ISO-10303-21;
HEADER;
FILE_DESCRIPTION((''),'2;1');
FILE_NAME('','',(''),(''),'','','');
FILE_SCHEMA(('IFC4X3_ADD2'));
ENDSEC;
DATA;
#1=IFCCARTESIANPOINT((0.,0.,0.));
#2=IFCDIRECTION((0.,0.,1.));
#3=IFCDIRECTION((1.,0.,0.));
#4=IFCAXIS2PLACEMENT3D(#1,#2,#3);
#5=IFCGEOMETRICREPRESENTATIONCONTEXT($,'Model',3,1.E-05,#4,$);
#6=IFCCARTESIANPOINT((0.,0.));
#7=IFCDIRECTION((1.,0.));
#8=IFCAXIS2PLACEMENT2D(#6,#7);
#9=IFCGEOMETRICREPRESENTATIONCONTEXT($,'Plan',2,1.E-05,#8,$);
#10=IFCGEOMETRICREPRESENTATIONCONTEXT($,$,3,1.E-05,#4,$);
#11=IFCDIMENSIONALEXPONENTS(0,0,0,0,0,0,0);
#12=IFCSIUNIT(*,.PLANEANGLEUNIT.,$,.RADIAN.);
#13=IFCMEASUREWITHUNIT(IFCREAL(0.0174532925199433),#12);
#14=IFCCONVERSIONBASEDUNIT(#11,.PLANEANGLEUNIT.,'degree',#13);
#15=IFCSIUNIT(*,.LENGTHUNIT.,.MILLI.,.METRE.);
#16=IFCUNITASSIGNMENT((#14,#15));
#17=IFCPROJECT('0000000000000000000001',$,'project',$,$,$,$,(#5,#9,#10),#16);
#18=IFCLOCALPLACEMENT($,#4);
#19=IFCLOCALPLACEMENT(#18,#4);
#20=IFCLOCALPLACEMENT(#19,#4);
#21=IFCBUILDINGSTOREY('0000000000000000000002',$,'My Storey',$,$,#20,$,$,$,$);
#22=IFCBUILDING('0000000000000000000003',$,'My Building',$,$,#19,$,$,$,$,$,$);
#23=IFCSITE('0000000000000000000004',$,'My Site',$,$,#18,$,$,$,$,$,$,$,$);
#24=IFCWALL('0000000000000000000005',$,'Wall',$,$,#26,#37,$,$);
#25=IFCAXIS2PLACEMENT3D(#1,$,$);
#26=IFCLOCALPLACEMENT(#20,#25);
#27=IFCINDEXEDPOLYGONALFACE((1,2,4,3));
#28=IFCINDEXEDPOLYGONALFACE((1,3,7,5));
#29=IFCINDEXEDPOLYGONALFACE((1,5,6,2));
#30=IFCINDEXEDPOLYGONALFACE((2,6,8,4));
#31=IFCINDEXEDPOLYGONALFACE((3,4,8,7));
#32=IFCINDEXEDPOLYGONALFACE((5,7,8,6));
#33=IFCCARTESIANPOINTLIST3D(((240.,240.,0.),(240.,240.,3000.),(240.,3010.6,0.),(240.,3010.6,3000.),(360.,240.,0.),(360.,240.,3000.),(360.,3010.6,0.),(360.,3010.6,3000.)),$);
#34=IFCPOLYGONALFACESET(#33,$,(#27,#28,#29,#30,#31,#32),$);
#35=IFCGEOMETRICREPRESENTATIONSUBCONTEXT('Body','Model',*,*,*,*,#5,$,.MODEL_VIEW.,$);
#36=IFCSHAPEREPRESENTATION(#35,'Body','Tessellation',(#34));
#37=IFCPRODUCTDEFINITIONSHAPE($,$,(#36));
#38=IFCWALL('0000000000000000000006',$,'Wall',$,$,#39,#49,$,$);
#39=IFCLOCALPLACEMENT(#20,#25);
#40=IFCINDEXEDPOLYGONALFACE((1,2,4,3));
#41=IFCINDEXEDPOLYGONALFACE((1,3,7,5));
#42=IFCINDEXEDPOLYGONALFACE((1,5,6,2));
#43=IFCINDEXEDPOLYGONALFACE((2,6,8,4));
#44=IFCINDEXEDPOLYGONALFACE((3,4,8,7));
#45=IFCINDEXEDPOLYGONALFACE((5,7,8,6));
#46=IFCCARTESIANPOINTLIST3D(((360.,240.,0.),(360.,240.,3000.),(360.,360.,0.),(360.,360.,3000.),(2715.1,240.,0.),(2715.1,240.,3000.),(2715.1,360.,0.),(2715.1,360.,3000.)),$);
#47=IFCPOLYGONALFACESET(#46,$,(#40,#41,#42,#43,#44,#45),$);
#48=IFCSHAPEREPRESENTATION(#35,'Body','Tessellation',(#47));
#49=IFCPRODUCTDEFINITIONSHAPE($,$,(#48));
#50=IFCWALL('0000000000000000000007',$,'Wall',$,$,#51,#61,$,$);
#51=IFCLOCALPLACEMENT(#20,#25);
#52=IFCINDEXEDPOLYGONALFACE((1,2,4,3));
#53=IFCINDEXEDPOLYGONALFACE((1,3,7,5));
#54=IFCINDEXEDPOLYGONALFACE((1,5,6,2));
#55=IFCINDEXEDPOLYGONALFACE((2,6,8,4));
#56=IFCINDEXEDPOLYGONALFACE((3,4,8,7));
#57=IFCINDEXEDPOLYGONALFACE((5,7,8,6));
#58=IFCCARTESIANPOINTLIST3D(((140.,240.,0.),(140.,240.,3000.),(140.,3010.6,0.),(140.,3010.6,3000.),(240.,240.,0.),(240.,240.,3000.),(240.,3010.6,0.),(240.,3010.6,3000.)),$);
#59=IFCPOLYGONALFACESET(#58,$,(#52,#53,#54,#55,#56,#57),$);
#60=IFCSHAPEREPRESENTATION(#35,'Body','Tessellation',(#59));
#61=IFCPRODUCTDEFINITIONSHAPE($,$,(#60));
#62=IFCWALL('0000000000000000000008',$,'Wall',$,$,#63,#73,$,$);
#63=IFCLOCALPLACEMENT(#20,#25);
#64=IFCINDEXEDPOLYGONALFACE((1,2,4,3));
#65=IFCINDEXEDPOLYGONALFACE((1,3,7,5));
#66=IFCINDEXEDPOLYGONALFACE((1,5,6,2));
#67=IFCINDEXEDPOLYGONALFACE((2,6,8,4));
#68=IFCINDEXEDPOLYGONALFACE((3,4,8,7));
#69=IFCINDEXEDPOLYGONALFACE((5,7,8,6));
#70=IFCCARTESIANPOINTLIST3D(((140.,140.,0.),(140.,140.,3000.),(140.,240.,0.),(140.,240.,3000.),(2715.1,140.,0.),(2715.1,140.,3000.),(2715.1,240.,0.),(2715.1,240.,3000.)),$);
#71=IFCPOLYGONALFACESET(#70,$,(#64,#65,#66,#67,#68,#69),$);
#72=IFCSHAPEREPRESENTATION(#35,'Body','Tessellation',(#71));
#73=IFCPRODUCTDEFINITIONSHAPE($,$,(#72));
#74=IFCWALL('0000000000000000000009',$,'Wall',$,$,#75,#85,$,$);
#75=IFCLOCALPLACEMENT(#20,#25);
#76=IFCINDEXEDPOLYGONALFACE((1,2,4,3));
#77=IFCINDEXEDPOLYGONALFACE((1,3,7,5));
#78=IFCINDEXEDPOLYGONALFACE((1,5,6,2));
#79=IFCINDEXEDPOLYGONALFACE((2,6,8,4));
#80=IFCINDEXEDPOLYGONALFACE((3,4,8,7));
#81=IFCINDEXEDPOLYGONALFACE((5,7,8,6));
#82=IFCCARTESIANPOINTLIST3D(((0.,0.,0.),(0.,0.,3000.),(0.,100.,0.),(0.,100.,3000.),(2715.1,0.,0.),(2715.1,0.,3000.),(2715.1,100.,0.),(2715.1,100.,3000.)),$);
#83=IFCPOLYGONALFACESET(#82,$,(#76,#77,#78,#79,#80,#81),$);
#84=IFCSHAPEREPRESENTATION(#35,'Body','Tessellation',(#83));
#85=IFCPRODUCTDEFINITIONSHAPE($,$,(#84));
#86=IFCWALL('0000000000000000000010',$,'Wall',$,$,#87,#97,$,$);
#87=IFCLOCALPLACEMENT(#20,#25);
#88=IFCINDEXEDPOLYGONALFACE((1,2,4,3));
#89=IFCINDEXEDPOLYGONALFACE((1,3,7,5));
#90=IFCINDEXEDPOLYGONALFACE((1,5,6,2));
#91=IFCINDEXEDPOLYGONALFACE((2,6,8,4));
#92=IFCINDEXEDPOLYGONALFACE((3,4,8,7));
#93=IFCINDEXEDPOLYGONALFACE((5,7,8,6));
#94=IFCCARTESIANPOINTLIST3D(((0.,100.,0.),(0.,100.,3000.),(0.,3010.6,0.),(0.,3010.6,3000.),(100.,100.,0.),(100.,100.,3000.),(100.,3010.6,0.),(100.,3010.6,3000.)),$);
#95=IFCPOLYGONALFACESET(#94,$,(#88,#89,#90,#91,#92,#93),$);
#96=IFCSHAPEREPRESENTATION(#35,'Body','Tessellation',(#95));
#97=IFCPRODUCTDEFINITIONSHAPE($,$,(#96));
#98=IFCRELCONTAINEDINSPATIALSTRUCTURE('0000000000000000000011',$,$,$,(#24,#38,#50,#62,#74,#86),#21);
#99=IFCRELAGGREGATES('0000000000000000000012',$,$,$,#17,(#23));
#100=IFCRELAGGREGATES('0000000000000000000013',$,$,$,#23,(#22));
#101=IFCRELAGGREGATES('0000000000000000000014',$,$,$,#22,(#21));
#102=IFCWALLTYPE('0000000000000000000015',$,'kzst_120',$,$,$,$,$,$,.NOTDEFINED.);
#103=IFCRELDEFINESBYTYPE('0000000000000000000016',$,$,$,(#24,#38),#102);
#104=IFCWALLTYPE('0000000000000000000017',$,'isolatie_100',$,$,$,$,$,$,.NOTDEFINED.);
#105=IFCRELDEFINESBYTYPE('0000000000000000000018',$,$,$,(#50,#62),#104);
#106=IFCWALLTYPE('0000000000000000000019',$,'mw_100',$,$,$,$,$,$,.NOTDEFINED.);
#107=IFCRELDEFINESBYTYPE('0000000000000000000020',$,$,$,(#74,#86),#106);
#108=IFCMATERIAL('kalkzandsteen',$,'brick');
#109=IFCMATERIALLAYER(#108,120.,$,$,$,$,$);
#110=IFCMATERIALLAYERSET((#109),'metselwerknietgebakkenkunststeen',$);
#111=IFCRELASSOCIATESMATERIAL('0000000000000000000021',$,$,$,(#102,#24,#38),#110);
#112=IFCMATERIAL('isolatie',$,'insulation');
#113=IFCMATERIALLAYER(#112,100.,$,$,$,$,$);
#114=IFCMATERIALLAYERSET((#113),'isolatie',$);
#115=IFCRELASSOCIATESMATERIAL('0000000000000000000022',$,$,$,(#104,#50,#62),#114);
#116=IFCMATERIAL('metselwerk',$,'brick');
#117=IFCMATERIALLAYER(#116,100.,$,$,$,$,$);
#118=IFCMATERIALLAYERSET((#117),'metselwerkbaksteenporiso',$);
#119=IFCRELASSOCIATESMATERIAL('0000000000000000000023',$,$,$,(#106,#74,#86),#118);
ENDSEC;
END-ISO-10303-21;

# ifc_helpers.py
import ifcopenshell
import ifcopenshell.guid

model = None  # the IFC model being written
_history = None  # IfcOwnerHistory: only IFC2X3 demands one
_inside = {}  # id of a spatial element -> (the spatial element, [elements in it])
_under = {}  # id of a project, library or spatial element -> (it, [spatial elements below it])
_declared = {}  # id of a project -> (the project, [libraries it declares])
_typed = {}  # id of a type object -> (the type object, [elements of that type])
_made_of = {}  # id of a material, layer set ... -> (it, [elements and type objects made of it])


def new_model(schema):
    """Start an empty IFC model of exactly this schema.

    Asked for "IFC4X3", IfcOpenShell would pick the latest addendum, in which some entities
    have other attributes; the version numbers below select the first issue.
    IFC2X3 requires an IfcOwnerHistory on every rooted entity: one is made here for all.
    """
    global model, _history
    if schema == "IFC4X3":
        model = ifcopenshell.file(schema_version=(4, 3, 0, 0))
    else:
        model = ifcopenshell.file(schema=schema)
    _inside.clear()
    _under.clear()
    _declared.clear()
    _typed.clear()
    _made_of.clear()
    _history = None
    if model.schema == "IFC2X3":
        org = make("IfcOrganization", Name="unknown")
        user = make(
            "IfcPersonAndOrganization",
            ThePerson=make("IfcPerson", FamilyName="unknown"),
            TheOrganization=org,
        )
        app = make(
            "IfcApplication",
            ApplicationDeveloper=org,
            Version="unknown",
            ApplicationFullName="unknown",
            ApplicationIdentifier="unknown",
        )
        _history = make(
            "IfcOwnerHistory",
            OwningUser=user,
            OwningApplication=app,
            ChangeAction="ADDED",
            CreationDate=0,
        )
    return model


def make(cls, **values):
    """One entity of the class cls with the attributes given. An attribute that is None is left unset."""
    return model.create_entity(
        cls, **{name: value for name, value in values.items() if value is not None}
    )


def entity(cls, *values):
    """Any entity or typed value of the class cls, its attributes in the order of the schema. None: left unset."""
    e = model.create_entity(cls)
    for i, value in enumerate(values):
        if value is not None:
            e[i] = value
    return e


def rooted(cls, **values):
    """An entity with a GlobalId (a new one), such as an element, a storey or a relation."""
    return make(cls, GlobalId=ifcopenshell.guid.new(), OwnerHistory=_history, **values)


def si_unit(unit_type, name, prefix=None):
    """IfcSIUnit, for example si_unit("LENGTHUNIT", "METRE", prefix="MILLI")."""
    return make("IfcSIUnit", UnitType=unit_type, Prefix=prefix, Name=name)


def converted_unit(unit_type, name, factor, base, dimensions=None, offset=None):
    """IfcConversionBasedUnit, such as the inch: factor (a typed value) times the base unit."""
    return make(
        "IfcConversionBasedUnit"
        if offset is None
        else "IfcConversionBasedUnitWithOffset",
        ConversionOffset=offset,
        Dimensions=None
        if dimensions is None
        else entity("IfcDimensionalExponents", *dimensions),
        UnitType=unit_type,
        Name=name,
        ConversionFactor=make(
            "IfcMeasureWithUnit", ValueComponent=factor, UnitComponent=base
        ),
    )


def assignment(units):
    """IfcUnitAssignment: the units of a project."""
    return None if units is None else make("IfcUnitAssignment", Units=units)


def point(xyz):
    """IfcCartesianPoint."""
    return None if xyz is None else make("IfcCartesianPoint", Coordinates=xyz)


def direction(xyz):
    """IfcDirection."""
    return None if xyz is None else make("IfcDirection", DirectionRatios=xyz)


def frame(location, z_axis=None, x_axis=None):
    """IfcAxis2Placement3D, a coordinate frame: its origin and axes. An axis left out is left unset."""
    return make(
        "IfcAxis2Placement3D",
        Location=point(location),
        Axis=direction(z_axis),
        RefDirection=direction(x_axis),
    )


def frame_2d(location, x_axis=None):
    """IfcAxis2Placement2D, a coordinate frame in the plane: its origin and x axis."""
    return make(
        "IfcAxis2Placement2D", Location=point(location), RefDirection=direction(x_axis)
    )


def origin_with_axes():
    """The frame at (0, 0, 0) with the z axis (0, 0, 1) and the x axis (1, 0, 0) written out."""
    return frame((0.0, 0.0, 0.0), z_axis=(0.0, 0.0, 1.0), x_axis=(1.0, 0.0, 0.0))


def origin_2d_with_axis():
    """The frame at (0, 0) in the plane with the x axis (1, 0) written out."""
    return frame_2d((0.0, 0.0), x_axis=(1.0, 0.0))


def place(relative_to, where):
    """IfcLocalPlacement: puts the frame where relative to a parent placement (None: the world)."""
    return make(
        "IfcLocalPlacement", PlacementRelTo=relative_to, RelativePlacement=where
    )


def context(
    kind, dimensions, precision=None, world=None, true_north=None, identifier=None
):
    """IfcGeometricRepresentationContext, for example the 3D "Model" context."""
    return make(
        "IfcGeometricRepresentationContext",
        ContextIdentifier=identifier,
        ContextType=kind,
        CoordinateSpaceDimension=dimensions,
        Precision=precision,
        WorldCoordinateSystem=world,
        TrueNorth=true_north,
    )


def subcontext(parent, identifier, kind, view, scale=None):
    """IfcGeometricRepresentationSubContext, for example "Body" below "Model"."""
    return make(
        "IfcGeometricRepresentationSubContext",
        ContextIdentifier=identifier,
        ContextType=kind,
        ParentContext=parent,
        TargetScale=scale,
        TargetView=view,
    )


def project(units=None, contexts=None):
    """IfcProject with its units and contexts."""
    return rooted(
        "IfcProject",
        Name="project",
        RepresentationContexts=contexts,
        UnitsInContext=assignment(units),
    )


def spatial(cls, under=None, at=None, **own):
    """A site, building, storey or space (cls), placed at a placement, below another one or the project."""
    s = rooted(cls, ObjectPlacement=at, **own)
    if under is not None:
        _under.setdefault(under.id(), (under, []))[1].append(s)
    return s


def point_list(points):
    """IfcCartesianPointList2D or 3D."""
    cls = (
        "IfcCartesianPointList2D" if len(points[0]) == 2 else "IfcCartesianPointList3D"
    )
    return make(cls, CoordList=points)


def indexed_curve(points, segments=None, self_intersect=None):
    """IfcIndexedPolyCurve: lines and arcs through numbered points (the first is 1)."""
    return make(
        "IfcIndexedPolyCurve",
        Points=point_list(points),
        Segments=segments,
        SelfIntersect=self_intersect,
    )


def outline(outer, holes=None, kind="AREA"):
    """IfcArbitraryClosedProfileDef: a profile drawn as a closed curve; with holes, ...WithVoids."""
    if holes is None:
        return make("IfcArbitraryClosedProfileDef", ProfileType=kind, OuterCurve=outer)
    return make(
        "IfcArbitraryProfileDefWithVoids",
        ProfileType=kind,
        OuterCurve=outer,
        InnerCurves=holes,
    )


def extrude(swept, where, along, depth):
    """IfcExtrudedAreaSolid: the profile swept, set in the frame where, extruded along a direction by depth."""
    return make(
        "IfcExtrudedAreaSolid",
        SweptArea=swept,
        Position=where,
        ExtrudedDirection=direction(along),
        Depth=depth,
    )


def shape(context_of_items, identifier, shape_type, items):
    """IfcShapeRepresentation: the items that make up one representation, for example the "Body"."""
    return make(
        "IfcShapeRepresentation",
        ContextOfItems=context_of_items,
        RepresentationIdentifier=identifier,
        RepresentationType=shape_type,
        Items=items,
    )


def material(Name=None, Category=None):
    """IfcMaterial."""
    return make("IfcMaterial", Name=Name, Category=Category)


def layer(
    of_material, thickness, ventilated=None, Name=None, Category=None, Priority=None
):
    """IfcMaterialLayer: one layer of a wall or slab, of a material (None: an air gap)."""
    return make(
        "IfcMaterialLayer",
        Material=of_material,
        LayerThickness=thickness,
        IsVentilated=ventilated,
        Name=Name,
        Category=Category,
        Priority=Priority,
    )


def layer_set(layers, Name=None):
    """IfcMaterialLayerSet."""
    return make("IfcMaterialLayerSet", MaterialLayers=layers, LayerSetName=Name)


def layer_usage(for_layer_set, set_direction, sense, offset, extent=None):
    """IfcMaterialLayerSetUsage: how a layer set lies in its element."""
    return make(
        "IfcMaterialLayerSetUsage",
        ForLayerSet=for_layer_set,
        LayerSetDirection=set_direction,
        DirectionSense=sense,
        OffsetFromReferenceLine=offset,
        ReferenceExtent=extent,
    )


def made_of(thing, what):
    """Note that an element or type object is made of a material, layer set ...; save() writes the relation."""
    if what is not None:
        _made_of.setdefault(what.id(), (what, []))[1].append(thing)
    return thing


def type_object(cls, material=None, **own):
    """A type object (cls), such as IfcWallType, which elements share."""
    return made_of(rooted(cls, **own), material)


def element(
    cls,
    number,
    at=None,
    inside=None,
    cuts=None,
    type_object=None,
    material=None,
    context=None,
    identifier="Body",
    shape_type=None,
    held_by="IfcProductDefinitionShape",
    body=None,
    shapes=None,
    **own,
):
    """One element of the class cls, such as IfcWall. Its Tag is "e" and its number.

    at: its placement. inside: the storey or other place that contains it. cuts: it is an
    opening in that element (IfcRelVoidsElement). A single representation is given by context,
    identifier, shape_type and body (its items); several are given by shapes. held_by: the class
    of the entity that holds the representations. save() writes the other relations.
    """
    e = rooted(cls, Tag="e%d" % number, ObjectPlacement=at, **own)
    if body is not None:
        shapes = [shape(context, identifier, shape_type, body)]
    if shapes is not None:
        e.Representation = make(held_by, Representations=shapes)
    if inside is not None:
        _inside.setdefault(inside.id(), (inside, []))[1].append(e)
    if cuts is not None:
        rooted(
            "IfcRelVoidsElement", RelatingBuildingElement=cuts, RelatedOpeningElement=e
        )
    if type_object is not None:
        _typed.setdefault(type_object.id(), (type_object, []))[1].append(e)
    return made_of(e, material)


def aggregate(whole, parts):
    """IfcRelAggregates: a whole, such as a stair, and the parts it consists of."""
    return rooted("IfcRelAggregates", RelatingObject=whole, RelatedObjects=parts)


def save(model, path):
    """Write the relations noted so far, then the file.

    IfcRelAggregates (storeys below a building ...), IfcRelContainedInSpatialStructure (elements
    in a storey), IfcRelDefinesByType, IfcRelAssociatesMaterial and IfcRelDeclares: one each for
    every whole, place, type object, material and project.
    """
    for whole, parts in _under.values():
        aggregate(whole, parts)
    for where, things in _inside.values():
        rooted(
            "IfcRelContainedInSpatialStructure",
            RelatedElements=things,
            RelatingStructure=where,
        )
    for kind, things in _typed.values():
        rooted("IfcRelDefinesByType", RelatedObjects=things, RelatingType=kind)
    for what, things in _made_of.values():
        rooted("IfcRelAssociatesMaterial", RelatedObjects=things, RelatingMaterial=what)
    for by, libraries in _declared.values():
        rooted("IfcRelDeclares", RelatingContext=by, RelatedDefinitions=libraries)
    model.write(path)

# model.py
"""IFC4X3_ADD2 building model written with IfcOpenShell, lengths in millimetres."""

from ifc_helpers import new_model, entity, si_unit, converted_unit, frame, origin_with_axes, origin_2d_with_axis, place, context, subcontext, project, spatial, indexed_curve, outline, extrude, material, layer, layer_set, layer_usage, type_object, element, save


model = new_model("IFC4X3_ADD2")

# Units and contexts
plan_context = context("Plan", 2, precision=1e-05, world=origin_2d_with_axis())
model_context = context("Model", 3, precision=1e-05, world=origin_with_axes())
context_of_model = context(None, 3, precision=1e-05, world=origin_with_axes())
body_context = subcontext(model_context, "Body", "Model", "MODEL_VIEW")
ifc_project = project(units=[converted_unit("PLANEANGLEUNIT", "degree", entity("IfcReal", 0.0174532925199433), si_unit("PLANEANGLEUNIT", "RADIAN"), dimensions=[0, 0, 0, 0, 0, 0, 0]), si_unit("LENGTHUNIT", "METRE", prefix="MILLI")], contexts=[model_context, plan_context, context_of_model])

# Site, building, storey
site_placement = place(None, origin_with_axes())
site = spatial("IfcSite", under=ifc_project, at=site_placement, Name="My Site")
building_placement = place(site_placement, origin_with_axes())
building = spatial("IfcBuilding", under=site, at=building_placement, Name="My Building")
storey_placement = place(building_placement, origin_with_axes())
storey = spatial("IfcBuildingStorey", under=building, at=storey_placement, Name="My Storey")

# Walls
ifc_material_1 = material(Name="kalkzandsteen", Category="brick")
ifc_layer_1 = layer(ifc_material_1, 120.0)
ifc_layer_set_1 = layer_set([ifc_layer_1], Name="metselwerknietgebakkenkunststeen")
ifc_layer_usage_1 = layer_usage(ifc_layer_set_1, "AXIS2", "POSITIVE", 0.0)
wall_type_1 = type_object("IfcWallType", Name="kzst_120", PredefinedType="NOTDEFINED", material=ifc_layer_set_1)
wall_1_placement = place(storey_placement, frame((360.0, 240.0, 0.0), z_axis=(0.0, 0.0, 1.0), x_axis=(0.0, 1.0, 0.0)))
element("IfcWall", 1, at=wall_1_placement, inside=storey, type_object=wall_type_1, material=ifc_layer_usage_1, Name="Wall", context=body_context, shape_type="SweptSolid", body=[
    extrude(outline(indexed_curve([(0.0, 0.0), (0.0, 120.0), (2770.6, 120.0), (2770.6, 0.0), (0.0, 0.0)], self_intersect=False)), origin_with_axes(), (0.0, 0.0, 1.0), 3000.0),
])
ifc_layer_usage_2 = layer_usage(ifc_layer_set_1, "AXIS2", "POSITIVE", 0.0)
wall_2_placement = place(storey_placement, frame((360.0, 240.0, 0.0), z_axis=(0.0, 0.0, 1.0), x_axis=(1.0, 0.0, 0.0)))
element("IfcWall", 2, at=wall_2_placement, inside=storey, type_object=wall_type_1, material=ifc_layer_usage_2, Name="Wall", context=body_context, shape_type="SweptSolid", body=[
    extrude(outline(indexed_curve([(0.0, 0.0), (0.0, 120.0), (2355.1, 120.0), (2355.1, 0.0), (0.0, 0.0)], self_intersect=False)), origin_with_axes(), (0.0, 0.0, 1.0), 3000.0),
])
ifc_material_2 = material(Name="isolatie", Category="insulation")
ifc_layer_2 = layer(ifc_material_2, 100.0)
ifc_layer_set_2 = layer_set([ifc_layer_2], Name="isolatie")
ifc_layer_usage_3 = layer_usage(ifc_layer_set_2, "AXIS2", "POSITIVE", 0.0)
wall_type_2 = type_object("IfcWallType", Name="isolatie_100", PredefinedType="NOTDEFINED", material=ifc_layer_set_2)
wall_3_placement = place(storey_placement, frame((240.0, 240.0, 0.0), z_axis=(0.0, 0.0, 1.0), x_axis=(0.0, 1.0, 0.0)))
element("IfcWall", 3, at=wall_3_placement, inside=storey, type_object=wall_type_2, material=ifc_layer_usage_3, Name="Wall", context=body_context, shape_type="SweptSolid", body=[
    extrude(outline(indexed_curve([(0.0, 0.0), (0.0, 100.0), (2770.6, 100.0), (2770.6, 0.0), (0.0, 0.0)], self_intersect=False)), origin_with_axes(), (0.0, 0.0, 1.0), 3000.0),
])
ifc_layer_usage_4 = layer_usage(ifc_layer_set_2, "AXIS2", "POSITIVE", 0.0)
wall_4_placement = place(storey_placement, frame((140.0, 140.0, 0.0), z_axis=(0.0, 0.0, 1.0), x_axis=(1.0, 0.0, 0.0)))
element("IfcWall", 4, at=wall_4_placement, inside=storey, type_object=wall_type_2, material=ifc_layer_usage_4, Name="Wall", context=body_context, shape_type="SweptSolid", body=[
    extrude(outline(indexed_curve([(0.0, 0.0), (0.0, 100.0), (2575.1, 100.0), (2575.1, 0.0), (0.0, 0.0)], self_intersect=False)), origin_with_axes(), (0.0, 0.0, 1.0), 3000.0),
])
ifc_material_3 = material(Name="metselwerk", Category="brick")
ifc_layer_3 = layer(ifc_material_3, 100.0)
ifc_layer_set_3 = layer_set([ifc_layer_3], Name="metselwerkbaksteenporiso")
ifc_layer_usage_5 = layer_usage(ifc_layer_set_3, "AXIS2", "POSITIVE", 0.0)
wall_type_3 = type_object("IfcWallType", Name="mw_100", PredefinedType="NOTDEFINED", material=ifc_layer_set_3)
wall_5_placement = place(storey_placement, origin_with_axes())
element("IfcWall", 5, at=wall_5_placement, inside=storey, type_object=wall_type_3, material=ifc_layer_usage_5, Name="Wall", context=body_context, shape_type="SweptSolid", body=[
    extrude(outline(indexed_curve([(0.0, 0.0), (0.0, 100.0), (2715.1, 100.0), (2715.1, 0.0), (0.0, 0.0)], self_intersect=False)), origin_with_axes(), (0.0, 0.0, 1.0), 3000.0),
])
ifc_layer_usage_6 = layer_usage(ifc_layer_set_3, "AXIS2", "POSITIVE", 0.0)
wall_6_placement = place(storey_placement, frame((100.0, 100.0, 0.0), z_axis=(0.0, 0.0, 1.0), x_axis=(0.0, 1.0, 0.0)))
element("IfcWall", 6, at=wall_6_placement, inside=storey, type_object=wall_type_3, material=ifc_layer_usage_6, Name="Wall", context=body_context, shape_type="SweptSolid", body=[
    extrude(outline(indexed_curve([(0.0, 0.0), (0.0, 100.0), (2910.6, 100.0), (2910.6, 0.0), (0.0, 0.0)], self_intersect=False)), origin_with_axes(), (0.0, 0.0, 1.0), 3000.0),
])

save(model, "model.ifc")
